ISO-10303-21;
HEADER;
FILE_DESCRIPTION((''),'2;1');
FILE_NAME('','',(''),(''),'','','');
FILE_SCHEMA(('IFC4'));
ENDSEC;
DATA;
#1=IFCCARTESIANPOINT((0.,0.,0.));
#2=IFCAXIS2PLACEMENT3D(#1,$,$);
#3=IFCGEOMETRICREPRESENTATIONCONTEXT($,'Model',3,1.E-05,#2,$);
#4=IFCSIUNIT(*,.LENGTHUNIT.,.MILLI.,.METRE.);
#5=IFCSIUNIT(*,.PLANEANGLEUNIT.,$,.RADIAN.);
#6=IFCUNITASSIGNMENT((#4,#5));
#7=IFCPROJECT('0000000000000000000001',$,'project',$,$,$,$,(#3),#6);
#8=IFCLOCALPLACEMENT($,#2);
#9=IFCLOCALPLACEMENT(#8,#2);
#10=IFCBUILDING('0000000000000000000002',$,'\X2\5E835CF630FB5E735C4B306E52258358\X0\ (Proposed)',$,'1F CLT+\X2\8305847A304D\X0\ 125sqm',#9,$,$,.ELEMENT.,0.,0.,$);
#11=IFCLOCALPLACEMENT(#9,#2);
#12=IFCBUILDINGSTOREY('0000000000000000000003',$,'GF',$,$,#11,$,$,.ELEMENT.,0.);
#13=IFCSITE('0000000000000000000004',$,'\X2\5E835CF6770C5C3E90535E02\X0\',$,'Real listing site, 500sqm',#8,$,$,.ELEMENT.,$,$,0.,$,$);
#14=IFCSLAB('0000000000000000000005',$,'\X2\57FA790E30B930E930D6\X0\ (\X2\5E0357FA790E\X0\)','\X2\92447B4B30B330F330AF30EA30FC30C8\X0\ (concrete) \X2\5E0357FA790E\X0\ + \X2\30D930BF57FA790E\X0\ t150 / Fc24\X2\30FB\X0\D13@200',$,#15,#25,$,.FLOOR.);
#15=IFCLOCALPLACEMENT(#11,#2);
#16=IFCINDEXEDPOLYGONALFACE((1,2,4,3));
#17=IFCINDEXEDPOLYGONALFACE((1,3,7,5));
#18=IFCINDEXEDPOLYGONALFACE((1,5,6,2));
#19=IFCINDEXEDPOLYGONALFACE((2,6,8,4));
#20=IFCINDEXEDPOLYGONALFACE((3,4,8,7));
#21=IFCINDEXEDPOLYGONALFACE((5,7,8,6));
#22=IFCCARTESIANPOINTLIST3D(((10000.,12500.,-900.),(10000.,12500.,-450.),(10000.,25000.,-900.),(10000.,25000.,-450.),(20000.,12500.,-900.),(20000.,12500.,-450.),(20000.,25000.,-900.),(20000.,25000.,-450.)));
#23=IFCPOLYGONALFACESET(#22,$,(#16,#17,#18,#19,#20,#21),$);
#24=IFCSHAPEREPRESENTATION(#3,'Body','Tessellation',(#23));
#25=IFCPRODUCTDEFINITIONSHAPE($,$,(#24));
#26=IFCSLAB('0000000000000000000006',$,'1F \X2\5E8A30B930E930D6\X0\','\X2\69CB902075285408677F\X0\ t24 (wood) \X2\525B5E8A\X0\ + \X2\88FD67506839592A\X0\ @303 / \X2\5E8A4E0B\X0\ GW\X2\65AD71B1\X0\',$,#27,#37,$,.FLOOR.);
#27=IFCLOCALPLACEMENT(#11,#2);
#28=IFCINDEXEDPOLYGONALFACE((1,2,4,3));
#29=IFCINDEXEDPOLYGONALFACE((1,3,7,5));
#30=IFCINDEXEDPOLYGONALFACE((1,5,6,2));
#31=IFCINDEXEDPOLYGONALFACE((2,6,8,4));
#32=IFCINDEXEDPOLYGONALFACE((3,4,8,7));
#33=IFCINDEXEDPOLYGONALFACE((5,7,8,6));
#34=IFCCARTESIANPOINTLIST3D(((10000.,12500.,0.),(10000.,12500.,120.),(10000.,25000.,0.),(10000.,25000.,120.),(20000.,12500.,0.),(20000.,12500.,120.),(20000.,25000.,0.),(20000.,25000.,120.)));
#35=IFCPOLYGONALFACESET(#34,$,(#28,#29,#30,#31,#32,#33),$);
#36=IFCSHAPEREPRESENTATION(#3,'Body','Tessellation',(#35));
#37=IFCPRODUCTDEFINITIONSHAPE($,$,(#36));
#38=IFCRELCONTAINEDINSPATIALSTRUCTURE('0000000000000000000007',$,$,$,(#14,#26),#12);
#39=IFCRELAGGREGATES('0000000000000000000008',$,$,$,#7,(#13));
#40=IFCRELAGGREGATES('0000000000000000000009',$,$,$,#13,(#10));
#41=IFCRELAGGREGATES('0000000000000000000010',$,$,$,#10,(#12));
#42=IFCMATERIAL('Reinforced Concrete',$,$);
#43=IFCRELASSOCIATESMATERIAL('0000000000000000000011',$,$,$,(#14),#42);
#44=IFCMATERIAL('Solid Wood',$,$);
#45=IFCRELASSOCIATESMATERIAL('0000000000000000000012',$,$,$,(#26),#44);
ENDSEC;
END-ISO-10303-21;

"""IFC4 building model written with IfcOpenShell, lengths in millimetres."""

from ifc_helpers import new_model, si_unit, frame, frame_2d, origin, place, context, project, spatial, rectangle, extrude, material, element, save


model = new_model("IFC4")

# Units and contexts
model_context = context("Model", 3, precision=1e-05, world=origin())
ifc_project = project(units=[si_unit("LENGTHUNIT", "METRE", prefix="MILLI"), si_unit("PLANEANGLEUNIT", "RADIAN")], contexts=[model_context])

# Site, building, storey
site_placement = place(None, origin())
site = spatial("IfcSite", under=ifc_project, at=site_placement, Name="広島県尾道市", ObjectType="Real listing site, 500sqm", CompositionType="ELEMENT", RefElevation=0.0)
building_placement = place(site_placement, origin())
building = spatial("IfcBuilding", under=site, at=building_placement, Name="広島・平屋の別荘 (Proposed)", ObjectType="1F CLT+茅葺き 125sqm", CompositionType="ELEMENT", ElevationOfRefHeight=0.0, ElevationOfTerrain=0.0)
storey_placement = place(building_placement, origin())
storey = spatial("IfcBuildingStorey", under=building, at=storey_placement, Name="GF", CompositionType="ELEMENT", Elevation=0.0)

# Shared definitions
ifc_material_1 = material(Name="Solid Wood")

# Slabs
ifc_material_2 = material(Name="Reinforced Concrete")
slab_1_placement = place(storey_placement, frame((5000.0, 6250.0, -450.0)))
element("IfcSlab", 1, at=slab_1_placement, inside=storey, material=ifc_material_2, Name="基礎スラブ (布基礎)", Description="鉄筋コンクリート (concrete) 布基礎 + ベタ基礎 t150 / Fc24・D13@200", PredefinedType="FLOOR", context=model_context, shape_type="SweptSolid", body=[
    extrude(rectangle(XDim=10000.0, YDim=12500.0, at=frame_2d((5000.0, 6250.0))), frame((5000.0, 6250.0, -450.0)), (0.0, 0.0, 1.0), 450.0),
])
slab_2_placement = place(storey_placement, frame((5000.0, 6250.0, 0.0)))
element("IfcSlab", 2, at=slab_2_placement, inside=storey, material=ifc_material_1, Name="1F 床スラブ", Description="構造用合板 t24 (wood) 剛床 + 製材根太 @303 / 床下 GW断熱", PredefinedType="FLOOR", context=model_context, shape_type="SweptSolid", body=[
    extrude(rectangle(XDim=10000.0, YDim=12500.0, at=frame_2d((5000.0, 6250.0))), frame((5000.0, 6250.0, 0.0)), (0.0, 0.0, 1.0), 120.0),
])

save(model, "model.ifc")
